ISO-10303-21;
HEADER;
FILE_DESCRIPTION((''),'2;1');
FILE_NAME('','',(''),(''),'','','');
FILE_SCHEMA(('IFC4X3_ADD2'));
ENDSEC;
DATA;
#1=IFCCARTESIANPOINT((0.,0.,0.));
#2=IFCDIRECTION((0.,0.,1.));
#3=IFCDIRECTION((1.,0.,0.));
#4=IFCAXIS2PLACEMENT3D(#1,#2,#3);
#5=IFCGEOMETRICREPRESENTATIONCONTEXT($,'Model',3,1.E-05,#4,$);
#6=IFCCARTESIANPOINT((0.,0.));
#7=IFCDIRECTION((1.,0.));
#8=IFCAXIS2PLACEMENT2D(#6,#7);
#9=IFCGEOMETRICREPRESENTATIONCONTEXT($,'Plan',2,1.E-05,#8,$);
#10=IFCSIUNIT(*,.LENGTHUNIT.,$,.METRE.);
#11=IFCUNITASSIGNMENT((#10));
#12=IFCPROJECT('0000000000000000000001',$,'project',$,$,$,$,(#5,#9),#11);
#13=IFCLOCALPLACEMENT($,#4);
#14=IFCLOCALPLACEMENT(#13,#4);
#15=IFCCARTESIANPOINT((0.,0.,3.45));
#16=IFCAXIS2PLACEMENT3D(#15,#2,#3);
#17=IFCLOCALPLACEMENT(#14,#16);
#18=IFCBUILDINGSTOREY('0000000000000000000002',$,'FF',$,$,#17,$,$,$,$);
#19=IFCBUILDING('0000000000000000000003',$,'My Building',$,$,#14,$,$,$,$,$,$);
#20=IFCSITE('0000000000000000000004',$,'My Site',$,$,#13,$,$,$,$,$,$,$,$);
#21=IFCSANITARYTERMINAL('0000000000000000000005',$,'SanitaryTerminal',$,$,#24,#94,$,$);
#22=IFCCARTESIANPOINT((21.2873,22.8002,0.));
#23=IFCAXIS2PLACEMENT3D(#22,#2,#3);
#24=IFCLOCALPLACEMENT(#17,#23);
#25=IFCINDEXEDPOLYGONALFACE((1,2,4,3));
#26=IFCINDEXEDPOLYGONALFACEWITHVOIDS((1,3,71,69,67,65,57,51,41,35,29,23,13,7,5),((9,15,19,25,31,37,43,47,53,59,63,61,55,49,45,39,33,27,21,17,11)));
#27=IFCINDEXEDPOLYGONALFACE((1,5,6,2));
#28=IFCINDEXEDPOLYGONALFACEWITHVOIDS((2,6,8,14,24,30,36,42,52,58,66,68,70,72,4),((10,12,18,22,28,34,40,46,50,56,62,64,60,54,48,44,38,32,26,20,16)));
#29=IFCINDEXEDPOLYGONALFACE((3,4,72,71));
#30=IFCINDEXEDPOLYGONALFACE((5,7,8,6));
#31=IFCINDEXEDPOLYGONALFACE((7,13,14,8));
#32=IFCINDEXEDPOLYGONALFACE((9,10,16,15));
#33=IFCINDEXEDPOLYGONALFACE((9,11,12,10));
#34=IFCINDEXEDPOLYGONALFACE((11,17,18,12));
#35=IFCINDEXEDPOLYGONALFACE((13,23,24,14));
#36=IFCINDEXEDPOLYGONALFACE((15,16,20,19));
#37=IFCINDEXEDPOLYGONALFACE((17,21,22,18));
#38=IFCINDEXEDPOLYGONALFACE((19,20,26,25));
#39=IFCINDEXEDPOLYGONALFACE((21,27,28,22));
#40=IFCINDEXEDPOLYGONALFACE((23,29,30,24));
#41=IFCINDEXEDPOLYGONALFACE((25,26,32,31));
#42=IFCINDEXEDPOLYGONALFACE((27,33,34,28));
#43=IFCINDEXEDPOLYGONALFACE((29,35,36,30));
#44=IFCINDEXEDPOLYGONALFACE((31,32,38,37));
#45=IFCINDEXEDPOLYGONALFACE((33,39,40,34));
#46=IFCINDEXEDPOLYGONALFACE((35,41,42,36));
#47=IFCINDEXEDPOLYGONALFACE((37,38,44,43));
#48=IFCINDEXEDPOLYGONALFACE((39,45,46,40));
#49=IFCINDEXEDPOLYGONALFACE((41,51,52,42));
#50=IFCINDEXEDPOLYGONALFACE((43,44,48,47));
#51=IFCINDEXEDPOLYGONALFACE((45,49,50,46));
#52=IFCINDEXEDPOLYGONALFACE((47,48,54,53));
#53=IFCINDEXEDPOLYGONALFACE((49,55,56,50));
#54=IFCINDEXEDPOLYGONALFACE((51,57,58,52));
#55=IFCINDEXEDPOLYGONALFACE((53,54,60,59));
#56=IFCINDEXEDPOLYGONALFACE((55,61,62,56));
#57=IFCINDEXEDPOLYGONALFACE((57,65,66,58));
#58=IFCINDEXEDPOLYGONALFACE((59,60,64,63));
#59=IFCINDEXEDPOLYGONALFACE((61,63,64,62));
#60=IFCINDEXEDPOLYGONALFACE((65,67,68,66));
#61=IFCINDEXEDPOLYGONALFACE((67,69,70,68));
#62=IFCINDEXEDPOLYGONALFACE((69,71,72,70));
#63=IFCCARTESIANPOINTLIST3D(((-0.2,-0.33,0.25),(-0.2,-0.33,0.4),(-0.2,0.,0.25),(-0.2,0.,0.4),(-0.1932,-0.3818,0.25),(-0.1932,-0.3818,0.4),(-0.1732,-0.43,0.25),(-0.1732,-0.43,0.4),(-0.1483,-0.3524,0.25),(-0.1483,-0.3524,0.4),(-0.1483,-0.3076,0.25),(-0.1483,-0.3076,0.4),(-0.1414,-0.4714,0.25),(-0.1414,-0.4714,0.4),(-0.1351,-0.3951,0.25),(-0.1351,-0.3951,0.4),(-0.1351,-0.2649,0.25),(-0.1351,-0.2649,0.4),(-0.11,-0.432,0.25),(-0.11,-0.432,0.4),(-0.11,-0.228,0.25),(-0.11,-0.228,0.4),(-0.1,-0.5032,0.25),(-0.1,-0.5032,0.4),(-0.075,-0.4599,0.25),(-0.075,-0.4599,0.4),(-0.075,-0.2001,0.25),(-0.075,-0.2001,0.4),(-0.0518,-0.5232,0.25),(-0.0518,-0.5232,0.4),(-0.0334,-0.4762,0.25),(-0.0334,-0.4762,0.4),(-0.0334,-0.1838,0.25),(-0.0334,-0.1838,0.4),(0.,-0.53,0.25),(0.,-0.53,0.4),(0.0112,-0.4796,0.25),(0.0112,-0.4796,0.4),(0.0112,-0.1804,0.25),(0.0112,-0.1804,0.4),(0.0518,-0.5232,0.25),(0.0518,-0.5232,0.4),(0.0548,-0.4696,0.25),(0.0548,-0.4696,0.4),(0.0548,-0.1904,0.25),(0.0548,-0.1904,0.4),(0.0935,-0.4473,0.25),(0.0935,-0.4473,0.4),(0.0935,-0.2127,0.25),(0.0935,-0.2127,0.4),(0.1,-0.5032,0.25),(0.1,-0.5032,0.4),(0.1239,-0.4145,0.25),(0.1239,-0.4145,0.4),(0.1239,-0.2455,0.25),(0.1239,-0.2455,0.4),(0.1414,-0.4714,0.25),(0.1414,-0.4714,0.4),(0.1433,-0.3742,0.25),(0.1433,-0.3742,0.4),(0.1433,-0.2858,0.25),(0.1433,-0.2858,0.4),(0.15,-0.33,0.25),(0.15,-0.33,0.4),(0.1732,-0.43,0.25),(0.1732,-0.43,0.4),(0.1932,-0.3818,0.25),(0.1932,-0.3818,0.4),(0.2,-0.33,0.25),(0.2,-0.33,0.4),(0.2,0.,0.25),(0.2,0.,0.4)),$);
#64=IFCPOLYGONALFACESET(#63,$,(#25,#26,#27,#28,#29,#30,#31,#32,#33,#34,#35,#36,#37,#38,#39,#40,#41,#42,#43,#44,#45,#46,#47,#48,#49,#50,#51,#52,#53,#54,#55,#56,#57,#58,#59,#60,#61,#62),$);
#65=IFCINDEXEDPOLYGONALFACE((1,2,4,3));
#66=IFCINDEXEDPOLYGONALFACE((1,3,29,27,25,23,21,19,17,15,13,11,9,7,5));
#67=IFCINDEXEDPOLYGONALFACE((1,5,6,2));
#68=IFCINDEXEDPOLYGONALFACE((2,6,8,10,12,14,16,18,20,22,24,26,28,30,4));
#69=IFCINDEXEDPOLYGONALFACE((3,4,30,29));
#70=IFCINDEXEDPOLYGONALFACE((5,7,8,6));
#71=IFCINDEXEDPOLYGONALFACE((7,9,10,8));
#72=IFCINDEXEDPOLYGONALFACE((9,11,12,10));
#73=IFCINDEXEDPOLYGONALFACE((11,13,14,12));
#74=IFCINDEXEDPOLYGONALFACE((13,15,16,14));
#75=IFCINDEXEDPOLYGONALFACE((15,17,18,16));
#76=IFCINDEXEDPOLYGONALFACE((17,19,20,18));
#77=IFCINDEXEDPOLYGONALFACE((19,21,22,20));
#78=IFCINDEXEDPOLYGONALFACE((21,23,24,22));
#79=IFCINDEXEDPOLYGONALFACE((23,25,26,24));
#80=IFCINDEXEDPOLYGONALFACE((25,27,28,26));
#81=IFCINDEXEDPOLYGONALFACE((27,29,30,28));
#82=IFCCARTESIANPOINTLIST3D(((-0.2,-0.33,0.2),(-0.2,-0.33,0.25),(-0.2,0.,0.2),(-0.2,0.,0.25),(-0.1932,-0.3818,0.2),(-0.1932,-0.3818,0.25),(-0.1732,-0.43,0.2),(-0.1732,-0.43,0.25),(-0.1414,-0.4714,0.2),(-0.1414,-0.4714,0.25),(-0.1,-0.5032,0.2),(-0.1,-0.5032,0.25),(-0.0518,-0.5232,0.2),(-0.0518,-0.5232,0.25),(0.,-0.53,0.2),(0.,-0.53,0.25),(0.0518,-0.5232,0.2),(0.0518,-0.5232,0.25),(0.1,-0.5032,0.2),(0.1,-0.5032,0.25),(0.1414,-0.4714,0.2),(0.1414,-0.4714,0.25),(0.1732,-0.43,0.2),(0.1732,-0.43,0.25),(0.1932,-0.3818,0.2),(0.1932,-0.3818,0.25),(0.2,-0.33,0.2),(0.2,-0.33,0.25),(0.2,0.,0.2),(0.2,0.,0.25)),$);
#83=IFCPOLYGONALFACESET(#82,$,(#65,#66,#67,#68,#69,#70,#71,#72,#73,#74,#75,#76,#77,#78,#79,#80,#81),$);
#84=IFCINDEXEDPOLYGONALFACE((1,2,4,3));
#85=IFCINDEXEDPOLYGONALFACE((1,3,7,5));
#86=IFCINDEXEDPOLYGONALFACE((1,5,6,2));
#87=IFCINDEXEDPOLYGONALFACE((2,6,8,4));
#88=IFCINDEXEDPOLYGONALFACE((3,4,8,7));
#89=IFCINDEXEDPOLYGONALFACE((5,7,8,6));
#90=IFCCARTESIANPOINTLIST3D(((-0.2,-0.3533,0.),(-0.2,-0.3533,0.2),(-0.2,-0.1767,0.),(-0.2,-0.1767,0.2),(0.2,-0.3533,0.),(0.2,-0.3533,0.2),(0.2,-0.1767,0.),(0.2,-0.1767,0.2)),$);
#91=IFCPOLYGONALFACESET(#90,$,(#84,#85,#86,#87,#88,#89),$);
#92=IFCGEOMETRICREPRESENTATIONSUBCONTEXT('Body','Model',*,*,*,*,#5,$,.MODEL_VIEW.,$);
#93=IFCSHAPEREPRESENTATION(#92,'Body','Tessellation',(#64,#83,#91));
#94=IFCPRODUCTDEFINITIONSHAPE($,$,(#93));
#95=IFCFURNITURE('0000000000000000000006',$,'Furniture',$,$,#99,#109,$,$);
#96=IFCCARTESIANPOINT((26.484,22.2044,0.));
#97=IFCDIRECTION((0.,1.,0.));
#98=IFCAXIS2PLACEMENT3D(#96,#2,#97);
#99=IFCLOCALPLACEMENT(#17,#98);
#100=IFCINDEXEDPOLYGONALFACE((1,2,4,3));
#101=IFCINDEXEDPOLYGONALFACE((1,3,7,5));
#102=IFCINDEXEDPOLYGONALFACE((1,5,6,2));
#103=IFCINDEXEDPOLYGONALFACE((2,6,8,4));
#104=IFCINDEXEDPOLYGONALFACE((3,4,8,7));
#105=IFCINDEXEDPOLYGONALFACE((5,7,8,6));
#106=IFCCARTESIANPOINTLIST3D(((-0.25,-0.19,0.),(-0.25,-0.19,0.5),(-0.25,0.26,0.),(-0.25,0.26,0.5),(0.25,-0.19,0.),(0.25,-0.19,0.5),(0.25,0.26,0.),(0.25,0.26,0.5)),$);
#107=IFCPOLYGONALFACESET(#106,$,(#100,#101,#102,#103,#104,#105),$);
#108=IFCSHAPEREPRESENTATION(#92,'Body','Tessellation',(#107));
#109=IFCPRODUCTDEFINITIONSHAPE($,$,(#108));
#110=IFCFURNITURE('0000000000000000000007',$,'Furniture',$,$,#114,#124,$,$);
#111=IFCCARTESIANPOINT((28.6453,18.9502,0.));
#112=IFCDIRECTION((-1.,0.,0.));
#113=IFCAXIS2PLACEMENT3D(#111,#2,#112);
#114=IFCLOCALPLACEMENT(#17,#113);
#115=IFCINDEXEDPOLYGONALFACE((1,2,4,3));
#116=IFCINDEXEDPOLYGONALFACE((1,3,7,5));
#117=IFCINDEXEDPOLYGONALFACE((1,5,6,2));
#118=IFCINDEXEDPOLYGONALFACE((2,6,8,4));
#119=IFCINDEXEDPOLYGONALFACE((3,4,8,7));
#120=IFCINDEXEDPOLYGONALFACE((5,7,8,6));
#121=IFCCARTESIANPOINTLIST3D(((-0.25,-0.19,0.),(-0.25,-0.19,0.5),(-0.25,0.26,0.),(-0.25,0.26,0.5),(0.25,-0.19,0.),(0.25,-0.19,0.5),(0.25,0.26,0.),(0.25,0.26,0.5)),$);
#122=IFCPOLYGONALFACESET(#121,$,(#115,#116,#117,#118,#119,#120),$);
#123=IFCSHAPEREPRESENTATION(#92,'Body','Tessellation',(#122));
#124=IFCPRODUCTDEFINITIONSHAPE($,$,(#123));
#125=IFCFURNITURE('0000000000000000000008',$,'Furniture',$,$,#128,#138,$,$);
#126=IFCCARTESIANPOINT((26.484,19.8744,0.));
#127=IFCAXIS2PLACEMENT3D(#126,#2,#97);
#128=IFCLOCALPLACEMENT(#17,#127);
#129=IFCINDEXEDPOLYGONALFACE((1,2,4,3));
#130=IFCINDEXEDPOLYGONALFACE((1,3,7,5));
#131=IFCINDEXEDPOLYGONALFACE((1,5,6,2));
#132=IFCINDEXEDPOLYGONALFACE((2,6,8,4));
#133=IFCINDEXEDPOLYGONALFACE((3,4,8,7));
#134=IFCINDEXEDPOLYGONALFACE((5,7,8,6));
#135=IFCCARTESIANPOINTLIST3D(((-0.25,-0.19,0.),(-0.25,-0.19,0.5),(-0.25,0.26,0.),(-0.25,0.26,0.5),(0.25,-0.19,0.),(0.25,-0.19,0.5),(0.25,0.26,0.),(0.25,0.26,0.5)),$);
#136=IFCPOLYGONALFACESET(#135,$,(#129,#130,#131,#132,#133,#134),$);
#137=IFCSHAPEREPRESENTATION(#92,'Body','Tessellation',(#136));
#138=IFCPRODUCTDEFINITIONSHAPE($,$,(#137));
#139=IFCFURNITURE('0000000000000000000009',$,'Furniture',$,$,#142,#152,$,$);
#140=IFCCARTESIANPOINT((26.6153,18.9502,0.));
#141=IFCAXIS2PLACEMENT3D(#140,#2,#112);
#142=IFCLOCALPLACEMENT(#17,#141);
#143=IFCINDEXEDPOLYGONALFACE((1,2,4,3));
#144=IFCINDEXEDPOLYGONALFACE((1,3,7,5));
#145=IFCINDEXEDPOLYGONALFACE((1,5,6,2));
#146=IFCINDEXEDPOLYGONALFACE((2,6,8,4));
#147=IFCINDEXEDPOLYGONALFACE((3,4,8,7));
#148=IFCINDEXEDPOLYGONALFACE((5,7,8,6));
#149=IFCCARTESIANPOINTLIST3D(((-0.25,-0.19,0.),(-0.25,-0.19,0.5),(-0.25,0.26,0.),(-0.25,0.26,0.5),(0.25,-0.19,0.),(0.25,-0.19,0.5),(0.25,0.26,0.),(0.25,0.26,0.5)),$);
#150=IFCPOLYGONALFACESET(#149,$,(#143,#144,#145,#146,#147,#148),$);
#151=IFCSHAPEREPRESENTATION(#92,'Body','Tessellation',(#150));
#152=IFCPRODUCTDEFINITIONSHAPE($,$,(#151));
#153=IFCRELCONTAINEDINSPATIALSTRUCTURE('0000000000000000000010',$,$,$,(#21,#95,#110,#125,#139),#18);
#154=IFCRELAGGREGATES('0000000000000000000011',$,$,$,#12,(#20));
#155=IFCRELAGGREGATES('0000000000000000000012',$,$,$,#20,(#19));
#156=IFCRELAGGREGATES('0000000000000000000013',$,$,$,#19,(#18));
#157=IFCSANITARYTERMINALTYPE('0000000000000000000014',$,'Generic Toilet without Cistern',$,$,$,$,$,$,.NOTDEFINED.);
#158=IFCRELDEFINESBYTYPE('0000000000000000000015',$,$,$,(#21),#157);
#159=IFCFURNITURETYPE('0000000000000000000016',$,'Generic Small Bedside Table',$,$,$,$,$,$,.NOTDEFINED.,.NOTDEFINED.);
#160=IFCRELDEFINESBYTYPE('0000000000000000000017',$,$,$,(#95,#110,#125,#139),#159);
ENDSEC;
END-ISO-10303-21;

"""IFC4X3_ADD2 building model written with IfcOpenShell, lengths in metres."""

from ifc_helpers import new_model, entity, si_unit, frame, frame_2d, origin_with_axes, origin_2d_with_axis, place, context, subcontext, project, spatial, line, arc, indexed_curve, circle_curve, outline, extrude, shape, source, transform, mapped, type_object, type_shapes, element, save


model = new_model("IFC4X3_ADD2")

# Units and contexts
model_context = context("Model", 3, precision=1e-05, world=origin_with_axes())
plan_context = context("Plan", 2, precision=1e-05, world=origin_2d_with_axis())
body_context_1 = subcontext(model_context, "Body", "Model", "MODEL_VIEW")
body_context_2 = subcontext(plan_context, "Body", "Plan", "PLAN_VIEW")
ifc_project = project(units=[si_unit("LENGTHUNIT", "METRE")], contexts=[model_context, plan_context])

# Site, building, storey
site_placement = place(None, origin_with_axes())
site = spatial("IfcSite", under=ifc_project, at=site_placement, Name="My Site")
building_placement = place(site_placement, origin_with_axes())
building = spatial("IfcBuilding", under=site, at=building_placement, Name="My Building")
storey_placement = place(building_placement, frame((0.0, 0.0, 3.45), z_axis=(0.0, 0.0, 1.0), x_axis=(1.0, 0.0, 0.0)))
storey = spatial("IfcBuildingStorey", under=building, at=storey_placement, Name="FF")

# Sanitary terminal
sanitary_terminal_type_1 = type_object("IfcSanitaryTerminalType", Name="Generic Toilet without Cistern", PredefinedType="NOTDEFINED")
shared_shape_1 = source(origin_with_axes(), body_context_1, "Body", "SweptSolid", [
    extrude(outline(indexed_curve([(-0.2, 0.0), (0.2, 0.0), (0.2, -0.33), (0.1414, -0.4714), (0.0, -0.53), (-0.1414, -0.4714), (-0.2, -0.33)], segments=[line(1, 2), line(2, 3), arc(3, 4, 5), arc(5, 6, 7), line(7, 1)]), holes=[circle_curve(frame_2d((0.0, -0.33)), 0.15)]), frame((0.0, 0.0, 0.25), z_axis=(0.0, 0.0, 1.0), x_axis=(1.0, 0.0, 0.0)), (0.0, 0.0, 1.0), 0.15),
    extrude(outline(indexed_curve([(-0.2, 0.0), (0.2, 0.0), (0.2, -0.33), (0.1414, -0.4714), (0.0, -0.53), (-0.1414, -0.4714), (-0.2, -0.33)], segments=[line(1, 2), line(2, 3), arc(3, 4, 5), arc(5, 6, 7), line(7, 1)])), frame((0.0, 0.0, 0.2), z_axis=(0.0, 0.0, 1.0), x_axis=(1.0, 0.0, 0.0)), (0.0, 0.0, 1.0), 0.05),
    extrude(outline(indexed_curve([(-0.2, -0.1767), (0.2, -0.1767), (0.2, -0.3533), (-0.2, -0.3533)], segments=[line(1, 2, 3, 4, 1)])), origin_with_axes(), (0.0, 0.0, 1.0), 0.2),
])
shared_shape_2 = source(origin_with_axes(), body_context_2, "Body", "Annotation2D", [
    entity("IfcGeometricCurveSet", [entity("IfcIndexedPolyCurve", entity("IfcCartesianPointList2D", [[-0.1068, -0.124], [-0.0957, -0.1129], [-0.0804, -0.1088], [0.0804, -0.1088], [0.0957, -0.1129], [0.1068, -0.124], [0.1109, -0.1393], [0.1109, -0.3476], [0.1025, -0.3926], [0.0784, -0.4308], [0.0424, -0.4563], [0.0, -0.4652], [-0.0424, -0.4563], [-0.0784, -0.4308], [-0.1025, -0.3926], [-0.1109, -0.3476], [-0.1109, -0.1393]]), [entity("IfcLineIndex", [1, 2, 3, 4, 5, 6, 7, 8, 9, 10, 11, 12, 13, 14, 15, 16, 17, 1])]), entity("IfcIndexedPolyCurve", entity("IfcCartesianPointList2D", [[-0.1962, -0.2314], [-0.1848, -0.301], [-0.1764, -0.3339], [-0.1663, -0.3651], [-0.1546, -0.3944], [-0.1414, -0.4213], [-0.1269, -0.4458], [-0.1111, -0.4675], [-0.0943, -0.4862], [-0.0765, -0.5018], [-0.0581, -0.514], [-0.039, -0.5229], [-0.0196, -0.5282], [0.0, -0.53], [0.0196, -0.5282], [0.039, -0.5229], [0.0581, -0.514], [0.0765, -0.5018], [0.0943, -0.4862], [0.1111, -0.4675], [0.1269, -0.4458], [0.1414, -0.4213], [0.1546, -0.3944], [0.1663, -0.3651], [0.1764, -0.3339], [0.1848, -0.301], [0.1962, -0.2314], [0.2, -0.159], [0.1872, 0.0], [-0.1872, 0.0], [-0.2, -0.159]]), [entity("IfcLineIndex", [1, 2, 3, 4, 5, 6, 7, 8, 9, 10, 11, 12, 13, 14, 15, 16, 17, 18, 19, 20, 21, 22, 23, 24, 25, 26, 27, 28, 29, 30, 31, 1])])]),
])
type_shapes(sanitary_terminal_type_1, [shared_shape_1, shared_shape_2])
sanitary_terminal_1_placement = place(storey_placement, frame((21.2873, 22.8002, 0.0), z_axis=(0.0, 0.0, 1.0), x_axis=(1.0, 0.0, 0.0)))
element("IfcSanitaryTerminal", 1, at=sanitary_terminal_1_placement, inside=storey, type_object=sanitary_terminal_type_1, Name="SanitaryTerminal", shapes=[
    shape(body_context_1, "Body", "MappedRepresentation", [mapped(shared_shape_1, transform((0.0, 0.0, 0.0), x_axis=(1.0, 0.0, 0.0), y_axis=(0.0, 1.0, 0.0), z_axis=(0.0, 0.0, 1.0), scale=1.0))]),
    shape(body_context_2, "Body", "MappedRepresentation", [mapped(shared_shape_2, transform((0.0, 0.0, 0.0), x_axis=(1.0, 0.0, 0.0), y_axis=(0.0, 1.0, 0.0), z_axis=(0.0, 0.0, 1.0), scale=1.0))]),
])

# Furniture
furniture_type_1 = type_object("IfcFurnitureType", Name="Generic Small Bedside Table", AssemblyPlace="NOTDEFINED", PredefinedType="NOTDEFINED")
shared_shape_3 = source(origin_with_axes(), body_context_1, "Body", "SweptSolid", [
    extrude(outline(indexed_curve([(0.5, 0.45), (0.5, 0.0), (0.0, 0.0), (0.0, 0.45)], segments=[line(4, 1), line(1, 2), line(2, 3), line(3, 4)], self_intersect=False)), frame((-0.25, -0.19, 0.0), z_axis=(0.0, 0.0, 1.0), x_axis=(1.0, 0.0, 0.0)), (0.0, 0.0, 1.0), 0.5),
])
shared_shape_4 = source(origin_with_axes(), body_context_2, "Body", "Annotation2D", [
    entity("IfcGeometricCurveSet", [entity("IfcIndexedPolyCurve", entity("IfcCartesianPointList2D", [[-0.25, -0.19], [0.25, -0.19], [0.25, 0.26], [-0.25, 0.26]]), [entity("IfcLineIndex", [1, 2]), entity("IfcLineIndex", [2, 3]), entity("IfcLineIndex", [3, 4]), entity("IfcLineIndex", [4, 1])])]),
])
type_shapes(furniture_type_1, [shared_shape_3, shared_shape_4])
for number, where, z_axis, x_axis, name in (
    (2, (26.484, 22.2044, 0.0), (0.0, 0.0, 1.0), (0.0, 1.0, 0.0), "Furniture"),
    (3, (28.6453, 18.9502, 0.0), (0.0, 0.0, 1.0), (-1.0, 0.0, 0.0), "Furniture"),
    (4, (26.484, 19.8744, 0.0), (0.0, 0.0, 1.0), (0.0, 1.0, 0.0), "Furniture"),
    (5, (26.6153, 18.9502, 0.0), (0.0, 0.0, 1.0), (-1.0, 0.0, 0.0), "Furniture"),
):
    element("IfcFurniture", number, at=place(storey_placement, frame(where, z_axis=z_axis, x_axis=x_axis)), inside=storey, type_object=furniture_type_1, Name=name, shapes=[
        shape(body_context_1, "Body", "MappedRepresentation", [mapped(shared_shape_3, transform((0.0, 0.0, 0.0), x_axis=(1.0, 0.0, 0.0), y_axis=(0.0, 1.0, 0.0), z_axis=(0.0, 0.0, 1.0), scale=1.0))]),
        shape(body_context_2, "Body", "MappedRepresentation", [mapped(shared_shape_4, transform((0.0, 0.0, 0.0), x_axis=(1.0, 0.0, 0.0), y_axis=(0.0, 1.0, 0.0), z_axis=(0.0, 0.0, 1.0), scale=1.0))]),
    ])

save(model, "model.ifc")
